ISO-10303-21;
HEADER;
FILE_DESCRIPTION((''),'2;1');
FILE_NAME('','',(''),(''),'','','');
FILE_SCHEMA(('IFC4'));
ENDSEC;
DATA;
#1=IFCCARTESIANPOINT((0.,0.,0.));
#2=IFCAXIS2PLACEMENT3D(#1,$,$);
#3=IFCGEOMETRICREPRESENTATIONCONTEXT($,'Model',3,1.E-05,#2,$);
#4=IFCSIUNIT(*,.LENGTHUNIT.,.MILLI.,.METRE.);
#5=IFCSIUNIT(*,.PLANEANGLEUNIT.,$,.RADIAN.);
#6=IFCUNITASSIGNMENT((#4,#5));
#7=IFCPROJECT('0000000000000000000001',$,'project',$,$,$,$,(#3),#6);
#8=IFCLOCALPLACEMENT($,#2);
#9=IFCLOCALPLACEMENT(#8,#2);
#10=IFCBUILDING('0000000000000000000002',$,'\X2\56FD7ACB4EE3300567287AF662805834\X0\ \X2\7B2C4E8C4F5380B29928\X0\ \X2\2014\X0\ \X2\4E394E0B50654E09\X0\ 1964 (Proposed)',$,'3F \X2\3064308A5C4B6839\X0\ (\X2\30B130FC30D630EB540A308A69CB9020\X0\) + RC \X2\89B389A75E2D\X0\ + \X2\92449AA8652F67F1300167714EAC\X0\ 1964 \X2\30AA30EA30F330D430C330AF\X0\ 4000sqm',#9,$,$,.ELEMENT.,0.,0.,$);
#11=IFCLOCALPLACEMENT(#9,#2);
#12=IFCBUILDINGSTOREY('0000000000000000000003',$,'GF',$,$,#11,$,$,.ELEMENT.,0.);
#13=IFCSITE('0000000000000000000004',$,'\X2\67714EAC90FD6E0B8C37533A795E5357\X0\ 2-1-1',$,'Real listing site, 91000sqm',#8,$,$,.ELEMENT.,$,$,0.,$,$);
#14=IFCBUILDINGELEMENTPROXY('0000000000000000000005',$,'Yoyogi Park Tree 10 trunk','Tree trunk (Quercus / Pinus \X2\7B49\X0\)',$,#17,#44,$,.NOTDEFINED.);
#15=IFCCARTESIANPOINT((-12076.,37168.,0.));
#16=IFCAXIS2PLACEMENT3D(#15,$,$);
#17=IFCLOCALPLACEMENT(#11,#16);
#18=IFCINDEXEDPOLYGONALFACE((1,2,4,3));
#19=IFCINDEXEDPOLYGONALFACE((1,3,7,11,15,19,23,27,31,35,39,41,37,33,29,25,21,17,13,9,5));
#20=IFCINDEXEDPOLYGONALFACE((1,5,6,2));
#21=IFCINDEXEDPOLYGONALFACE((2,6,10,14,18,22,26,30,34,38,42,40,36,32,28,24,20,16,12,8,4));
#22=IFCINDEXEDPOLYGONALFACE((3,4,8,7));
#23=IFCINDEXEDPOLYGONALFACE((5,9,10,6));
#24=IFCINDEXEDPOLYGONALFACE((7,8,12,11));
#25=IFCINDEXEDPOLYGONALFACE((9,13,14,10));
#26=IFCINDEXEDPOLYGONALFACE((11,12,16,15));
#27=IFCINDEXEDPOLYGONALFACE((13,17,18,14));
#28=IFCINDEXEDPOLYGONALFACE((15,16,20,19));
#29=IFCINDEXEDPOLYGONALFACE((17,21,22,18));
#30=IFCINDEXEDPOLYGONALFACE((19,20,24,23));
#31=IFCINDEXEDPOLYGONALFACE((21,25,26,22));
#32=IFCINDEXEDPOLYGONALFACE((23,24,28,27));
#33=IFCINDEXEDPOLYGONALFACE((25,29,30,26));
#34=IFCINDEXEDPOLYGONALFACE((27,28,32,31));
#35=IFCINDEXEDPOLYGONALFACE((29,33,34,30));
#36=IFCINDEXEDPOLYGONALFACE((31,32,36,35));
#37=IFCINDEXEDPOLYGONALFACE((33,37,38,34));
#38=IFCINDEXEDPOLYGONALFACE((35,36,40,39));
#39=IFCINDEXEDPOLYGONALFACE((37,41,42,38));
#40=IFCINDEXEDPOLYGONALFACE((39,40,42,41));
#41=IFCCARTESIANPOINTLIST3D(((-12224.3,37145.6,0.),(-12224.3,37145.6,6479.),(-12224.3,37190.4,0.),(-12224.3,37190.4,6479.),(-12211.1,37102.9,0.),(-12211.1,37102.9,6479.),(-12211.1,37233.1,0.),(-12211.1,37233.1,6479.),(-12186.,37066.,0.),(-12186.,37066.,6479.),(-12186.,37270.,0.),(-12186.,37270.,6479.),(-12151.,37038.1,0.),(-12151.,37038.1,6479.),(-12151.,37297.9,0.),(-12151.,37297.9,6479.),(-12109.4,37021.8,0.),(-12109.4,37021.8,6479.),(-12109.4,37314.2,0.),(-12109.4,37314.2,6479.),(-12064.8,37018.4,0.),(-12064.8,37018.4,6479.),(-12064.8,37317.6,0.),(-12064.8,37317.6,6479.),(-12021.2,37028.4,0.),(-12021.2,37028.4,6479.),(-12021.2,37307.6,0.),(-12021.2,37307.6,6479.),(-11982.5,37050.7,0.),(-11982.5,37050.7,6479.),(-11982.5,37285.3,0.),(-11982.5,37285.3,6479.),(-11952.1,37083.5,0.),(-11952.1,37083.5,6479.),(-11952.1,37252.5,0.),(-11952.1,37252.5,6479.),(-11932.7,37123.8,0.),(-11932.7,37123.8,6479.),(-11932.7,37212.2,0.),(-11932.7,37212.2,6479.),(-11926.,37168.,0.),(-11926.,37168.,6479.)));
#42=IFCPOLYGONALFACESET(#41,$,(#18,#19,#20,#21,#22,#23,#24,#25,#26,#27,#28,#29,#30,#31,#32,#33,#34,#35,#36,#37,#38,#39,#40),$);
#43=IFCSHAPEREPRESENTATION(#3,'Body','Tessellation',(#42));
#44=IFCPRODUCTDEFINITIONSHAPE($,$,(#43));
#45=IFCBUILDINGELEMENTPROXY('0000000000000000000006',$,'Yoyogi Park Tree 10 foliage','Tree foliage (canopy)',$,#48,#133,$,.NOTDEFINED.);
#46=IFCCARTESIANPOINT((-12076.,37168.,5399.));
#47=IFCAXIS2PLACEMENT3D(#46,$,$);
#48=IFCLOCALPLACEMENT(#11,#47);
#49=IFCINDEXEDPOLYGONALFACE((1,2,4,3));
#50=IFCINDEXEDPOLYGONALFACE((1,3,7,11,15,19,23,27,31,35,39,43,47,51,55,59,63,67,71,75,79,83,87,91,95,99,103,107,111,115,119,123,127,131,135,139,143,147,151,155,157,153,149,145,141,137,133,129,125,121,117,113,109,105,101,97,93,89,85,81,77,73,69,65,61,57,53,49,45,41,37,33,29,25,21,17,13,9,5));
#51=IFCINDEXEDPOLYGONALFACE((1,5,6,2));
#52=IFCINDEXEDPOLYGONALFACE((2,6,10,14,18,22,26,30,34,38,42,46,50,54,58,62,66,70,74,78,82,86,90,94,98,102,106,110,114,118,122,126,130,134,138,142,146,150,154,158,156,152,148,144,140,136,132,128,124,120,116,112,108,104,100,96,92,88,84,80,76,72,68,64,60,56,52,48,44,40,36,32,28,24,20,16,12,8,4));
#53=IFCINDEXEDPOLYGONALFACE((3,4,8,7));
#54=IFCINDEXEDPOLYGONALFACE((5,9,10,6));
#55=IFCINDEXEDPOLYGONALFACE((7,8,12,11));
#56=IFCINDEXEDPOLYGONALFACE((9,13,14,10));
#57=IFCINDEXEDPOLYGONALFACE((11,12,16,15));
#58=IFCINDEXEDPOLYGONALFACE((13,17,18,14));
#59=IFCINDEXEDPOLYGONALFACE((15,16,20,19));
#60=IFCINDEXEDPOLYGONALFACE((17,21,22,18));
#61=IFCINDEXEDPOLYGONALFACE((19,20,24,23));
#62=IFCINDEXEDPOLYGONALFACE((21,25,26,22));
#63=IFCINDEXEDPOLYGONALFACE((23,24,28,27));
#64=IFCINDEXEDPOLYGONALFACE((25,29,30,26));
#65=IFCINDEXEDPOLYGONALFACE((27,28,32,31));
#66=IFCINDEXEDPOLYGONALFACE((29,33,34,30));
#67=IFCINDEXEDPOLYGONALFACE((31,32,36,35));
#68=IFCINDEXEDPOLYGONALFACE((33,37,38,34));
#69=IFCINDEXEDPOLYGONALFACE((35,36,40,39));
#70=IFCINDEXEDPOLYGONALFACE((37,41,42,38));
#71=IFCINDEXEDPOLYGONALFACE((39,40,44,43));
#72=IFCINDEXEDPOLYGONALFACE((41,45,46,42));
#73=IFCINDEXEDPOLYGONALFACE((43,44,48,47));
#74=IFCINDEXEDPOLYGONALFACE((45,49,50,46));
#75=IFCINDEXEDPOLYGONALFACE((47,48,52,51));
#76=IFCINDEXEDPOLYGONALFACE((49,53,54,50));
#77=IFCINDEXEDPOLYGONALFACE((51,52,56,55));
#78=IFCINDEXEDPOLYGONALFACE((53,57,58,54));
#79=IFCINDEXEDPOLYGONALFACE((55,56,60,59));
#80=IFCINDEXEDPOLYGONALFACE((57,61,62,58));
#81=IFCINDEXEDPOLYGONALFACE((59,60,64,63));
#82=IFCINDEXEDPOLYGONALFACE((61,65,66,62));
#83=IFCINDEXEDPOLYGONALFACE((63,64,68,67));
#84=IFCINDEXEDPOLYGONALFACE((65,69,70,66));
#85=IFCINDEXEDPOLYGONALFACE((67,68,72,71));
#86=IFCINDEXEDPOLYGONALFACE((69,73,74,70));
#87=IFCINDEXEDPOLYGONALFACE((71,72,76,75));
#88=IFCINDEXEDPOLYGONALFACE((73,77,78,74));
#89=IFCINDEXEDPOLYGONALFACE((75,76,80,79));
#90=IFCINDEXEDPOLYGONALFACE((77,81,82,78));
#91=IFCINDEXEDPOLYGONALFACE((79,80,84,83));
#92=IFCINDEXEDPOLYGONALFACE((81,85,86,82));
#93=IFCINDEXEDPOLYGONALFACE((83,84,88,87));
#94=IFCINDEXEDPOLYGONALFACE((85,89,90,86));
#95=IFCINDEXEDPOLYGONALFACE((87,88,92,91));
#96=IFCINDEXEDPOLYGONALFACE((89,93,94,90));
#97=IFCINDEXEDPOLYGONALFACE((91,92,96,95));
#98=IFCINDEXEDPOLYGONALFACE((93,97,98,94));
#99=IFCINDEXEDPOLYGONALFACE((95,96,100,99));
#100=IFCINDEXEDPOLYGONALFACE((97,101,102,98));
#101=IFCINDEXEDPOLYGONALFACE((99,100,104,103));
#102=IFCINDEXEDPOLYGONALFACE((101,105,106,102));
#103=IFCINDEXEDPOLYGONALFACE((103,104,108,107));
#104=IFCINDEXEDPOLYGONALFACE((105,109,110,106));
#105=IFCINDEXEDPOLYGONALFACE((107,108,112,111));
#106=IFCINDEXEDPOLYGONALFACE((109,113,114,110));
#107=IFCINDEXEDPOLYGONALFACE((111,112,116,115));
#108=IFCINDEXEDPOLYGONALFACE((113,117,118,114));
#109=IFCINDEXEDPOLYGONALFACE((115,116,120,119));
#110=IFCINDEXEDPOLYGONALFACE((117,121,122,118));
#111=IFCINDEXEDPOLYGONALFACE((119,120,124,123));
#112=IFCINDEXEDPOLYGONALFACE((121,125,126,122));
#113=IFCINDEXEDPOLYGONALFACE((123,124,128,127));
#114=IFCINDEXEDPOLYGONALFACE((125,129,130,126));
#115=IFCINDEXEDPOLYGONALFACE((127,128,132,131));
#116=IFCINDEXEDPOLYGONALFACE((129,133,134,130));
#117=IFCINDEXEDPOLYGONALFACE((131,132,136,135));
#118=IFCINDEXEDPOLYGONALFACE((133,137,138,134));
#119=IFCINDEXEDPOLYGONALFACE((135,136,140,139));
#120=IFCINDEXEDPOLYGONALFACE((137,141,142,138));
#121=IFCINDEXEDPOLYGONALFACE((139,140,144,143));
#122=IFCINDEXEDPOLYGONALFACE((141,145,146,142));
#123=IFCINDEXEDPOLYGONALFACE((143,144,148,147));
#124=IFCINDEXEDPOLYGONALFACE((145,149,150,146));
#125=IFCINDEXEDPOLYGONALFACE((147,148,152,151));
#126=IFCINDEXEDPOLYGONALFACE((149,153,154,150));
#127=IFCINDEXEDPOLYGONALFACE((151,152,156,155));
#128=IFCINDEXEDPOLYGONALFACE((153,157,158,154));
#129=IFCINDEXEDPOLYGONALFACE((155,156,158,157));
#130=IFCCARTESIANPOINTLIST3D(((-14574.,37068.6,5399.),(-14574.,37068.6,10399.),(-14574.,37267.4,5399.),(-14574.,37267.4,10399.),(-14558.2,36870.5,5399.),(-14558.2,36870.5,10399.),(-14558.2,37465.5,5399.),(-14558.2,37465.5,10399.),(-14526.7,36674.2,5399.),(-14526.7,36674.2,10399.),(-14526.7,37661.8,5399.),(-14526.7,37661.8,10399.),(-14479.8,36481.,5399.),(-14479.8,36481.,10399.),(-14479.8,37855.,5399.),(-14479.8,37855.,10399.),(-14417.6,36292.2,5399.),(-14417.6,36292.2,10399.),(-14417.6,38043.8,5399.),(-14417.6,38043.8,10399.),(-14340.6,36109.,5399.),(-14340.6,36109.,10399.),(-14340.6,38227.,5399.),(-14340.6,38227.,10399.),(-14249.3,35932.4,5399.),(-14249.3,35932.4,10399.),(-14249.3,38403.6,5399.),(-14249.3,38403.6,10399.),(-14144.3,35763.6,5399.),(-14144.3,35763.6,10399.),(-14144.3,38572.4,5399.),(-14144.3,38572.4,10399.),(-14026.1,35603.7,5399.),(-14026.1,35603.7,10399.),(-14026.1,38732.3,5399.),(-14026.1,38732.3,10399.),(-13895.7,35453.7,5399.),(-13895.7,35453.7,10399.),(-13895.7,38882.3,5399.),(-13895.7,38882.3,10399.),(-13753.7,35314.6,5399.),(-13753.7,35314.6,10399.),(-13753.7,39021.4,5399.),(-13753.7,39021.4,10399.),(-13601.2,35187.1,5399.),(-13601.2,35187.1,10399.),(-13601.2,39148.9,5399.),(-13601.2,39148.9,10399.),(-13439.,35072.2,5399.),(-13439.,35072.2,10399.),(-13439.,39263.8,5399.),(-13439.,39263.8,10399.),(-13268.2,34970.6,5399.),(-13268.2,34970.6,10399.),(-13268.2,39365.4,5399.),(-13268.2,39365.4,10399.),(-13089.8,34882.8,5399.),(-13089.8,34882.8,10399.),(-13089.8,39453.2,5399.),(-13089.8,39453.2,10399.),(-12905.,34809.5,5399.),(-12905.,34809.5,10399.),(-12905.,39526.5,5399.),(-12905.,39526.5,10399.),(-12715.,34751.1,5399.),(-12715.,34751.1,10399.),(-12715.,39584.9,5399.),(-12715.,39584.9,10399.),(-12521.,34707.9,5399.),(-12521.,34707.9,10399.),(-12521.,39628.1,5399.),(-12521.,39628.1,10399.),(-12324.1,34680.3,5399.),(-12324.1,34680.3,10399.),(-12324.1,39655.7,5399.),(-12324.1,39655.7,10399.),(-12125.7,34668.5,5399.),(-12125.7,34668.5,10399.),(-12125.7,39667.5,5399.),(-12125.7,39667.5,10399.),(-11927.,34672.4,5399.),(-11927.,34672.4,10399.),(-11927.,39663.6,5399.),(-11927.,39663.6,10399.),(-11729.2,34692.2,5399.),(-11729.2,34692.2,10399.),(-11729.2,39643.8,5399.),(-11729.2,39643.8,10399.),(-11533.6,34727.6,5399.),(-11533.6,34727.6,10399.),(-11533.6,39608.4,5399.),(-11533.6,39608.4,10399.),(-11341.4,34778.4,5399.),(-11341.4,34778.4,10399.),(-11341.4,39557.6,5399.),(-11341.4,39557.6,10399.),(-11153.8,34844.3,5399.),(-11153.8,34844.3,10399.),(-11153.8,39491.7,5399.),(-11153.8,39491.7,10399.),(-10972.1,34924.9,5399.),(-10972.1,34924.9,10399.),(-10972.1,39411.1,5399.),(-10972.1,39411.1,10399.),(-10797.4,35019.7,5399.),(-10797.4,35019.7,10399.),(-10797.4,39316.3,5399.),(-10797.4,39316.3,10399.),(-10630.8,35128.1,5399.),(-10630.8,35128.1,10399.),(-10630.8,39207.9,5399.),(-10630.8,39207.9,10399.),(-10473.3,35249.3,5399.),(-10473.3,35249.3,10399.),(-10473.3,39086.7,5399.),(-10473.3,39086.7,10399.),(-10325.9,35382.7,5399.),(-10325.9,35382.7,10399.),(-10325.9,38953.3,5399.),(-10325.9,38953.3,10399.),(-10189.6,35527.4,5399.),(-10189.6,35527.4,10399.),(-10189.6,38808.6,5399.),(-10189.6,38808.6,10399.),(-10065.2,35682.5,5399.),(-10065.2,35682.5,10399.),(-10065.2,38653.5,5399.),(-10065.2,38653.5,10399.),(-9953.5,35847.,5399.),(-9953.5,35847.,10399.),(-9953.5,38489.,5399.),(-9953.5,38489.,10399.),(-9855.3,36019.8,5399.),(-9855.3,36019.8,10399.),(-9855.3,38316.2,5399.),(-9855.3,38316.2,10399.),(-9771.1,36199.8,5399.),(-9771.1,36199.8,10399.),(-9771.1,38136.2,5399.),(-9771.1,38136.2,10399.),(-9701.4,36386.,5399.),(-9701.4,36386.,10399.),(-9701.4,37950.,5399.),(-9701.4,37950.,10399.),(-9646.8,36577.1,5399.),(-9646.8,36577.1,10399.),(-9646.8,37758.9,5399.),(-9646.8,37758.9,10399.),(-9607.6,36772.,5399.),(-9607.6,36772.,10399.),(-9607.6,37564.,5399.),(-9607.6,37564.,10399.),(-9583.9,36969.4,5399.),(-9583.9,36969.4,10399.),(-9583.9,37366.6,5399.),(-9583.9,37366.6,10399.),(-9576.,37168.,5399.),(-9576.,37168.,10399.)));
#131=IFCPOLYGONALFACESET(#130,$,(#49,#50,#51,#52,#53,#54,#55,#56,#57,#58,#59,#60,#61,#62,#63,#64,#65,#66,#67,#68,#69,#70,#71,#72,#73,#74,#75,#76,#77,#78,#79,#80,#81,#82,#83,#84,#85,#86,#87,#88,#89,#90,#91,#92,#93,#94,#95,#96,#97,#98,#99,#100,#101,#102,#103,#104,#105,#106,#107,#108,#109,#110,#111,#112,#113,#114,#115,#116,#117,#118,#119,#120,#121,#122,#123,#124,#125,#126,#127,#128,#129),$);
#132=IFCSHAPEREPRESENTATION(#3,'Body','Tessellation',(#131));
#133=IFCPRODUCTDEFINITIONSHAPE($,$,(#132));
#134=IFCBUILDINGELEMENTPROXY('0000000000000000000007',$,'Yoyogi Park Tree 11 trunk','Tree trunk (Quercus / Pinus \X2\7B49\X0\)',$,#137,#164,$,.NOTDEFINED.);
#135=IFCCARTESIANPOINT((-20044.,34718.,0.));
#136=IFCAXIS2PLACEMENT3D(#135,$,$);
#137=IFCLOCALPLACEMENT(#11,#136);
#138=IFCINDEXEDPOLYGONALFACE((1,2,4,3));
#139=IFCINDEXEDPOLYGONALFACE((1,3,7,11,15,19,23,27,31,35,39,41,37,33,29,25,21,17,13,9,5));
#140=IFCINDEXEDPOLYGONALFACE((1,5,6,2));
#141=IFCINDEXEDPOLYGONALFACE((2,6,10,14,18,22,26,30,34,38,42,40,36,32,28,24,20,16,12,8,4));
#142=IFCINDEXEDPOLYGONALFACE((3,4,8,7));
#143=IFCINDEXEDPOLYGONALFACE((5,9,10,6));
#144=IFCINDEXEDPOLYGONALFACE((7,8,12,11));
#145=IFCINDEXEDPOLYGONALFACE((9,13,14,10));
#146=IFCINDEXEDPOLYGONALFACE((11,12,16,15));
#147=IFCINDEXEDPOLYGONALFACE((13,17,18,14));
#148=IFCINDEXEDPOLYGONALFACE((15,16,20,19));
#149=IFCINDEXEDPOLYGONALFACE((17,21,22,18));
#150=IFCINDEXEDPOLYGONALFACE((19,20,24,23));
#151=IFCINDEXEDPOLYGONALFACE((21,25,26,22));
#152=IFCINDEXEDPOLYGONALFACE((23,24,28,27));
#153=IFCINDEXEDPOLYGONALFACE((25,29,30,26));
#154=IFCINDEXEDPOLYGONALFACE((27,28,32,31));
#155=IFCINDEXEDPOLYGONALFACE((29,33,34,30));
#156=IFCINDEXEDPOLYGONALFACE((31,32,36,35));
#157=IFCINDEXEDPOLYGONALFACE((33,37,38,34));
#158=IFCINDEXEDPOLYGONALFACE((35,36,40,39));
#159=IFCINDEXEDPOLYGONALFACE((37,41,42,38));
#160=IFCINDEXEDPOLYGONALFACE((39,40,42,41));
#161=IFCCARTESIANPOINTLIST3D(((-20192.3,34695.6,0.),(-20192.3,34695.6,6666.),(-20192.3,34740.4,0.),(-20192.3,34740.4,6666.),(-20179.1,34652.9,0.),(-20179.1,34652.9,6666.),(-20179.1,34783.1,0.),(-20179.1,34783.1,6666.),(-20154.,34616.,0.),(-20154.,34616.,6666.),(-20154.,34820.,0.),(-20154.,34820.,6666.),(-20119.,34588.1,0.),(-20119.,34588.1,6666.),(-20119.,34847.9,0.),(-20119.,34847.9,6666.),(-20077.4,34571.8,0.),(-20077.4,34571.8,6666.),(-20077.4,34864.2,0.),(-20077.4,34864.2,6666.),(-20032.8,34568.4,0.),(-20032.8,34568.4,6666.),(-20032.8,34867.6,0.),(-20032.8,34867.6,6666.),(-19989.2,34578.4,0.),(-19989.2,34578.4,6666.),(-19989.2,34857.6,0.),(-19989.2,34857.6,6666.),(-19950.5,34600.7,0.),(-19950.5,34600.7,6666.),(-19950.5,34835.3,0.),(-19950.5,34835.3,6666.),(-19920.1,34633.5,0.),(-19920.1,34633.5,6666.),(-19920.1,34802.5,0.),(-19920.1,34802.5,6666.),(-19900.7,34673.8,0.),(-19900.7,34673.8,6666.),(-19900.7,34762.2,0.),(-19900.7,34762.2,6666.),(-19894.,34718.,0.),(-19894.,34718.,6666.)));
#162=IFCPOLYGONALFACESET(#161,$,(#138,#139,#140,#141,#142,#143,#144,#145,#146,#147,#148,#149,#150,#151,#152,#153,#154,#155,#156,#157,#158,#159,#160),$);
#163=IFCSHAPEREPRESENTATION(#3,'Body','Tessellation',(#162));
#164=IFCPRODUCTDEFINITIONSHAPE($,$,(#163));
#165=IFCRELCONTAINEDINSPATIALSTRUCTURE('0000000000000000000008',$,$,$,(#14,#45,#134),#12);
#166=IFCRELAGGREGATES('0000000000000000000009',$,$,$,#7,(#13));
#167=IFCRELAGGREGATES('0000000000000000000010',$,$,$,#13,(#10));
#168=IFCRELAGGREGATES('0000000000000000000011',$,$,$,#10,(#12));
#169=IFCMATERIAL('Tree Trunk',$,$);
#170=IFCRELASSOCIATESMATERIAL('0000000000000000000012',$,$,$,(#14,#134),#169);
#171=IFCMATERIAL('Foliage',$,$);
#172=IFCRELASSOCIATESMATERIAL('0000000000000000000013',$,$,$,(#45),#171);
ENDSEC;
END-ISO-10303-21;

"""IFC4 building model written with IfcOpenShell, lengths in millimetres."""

from ifc_helpers import new_model, si_unit, frame, origin, origin_2d, place, context, project, spatial, circle, extrude, material, element, save


model = new_model("IFC4")

# Units and contexts
model_context = context("Model", 3, precision=1e-05, world=origin())
ifc_project = project(units=[si_unit("LENGTHUNIT", "METRE", prefix="MILLI"), si_unit("PLANEANGLEUNIT", "RADIAN")], contexts=[model_context])

# Site, building, storey
site_placement = place(None, origin())
site = spatial("IfcSite", under=ifc_project, at=site_placement, Name="東京都渋谷区神南 2-1-1", ObjectType="Real listing site, 91000sqm", CompositionType="ELEMENT", RefElevation=0.0)
building_placement = place(site_placement, origin())
building = spatial("IfcBuilding", under=site, at=building_placement, Name="国立代々木競技場 第二体育館 — 丹下健三 1964 (Proposed)", ObjectType="3F つり屋根 (ケーブル吊り構造) + RC 観覧席 + 鉄骨支柱、東京 1964 オリンピック 4000sqm", CompositionType="ELEMENT", ElevationOfRefHeight=0.0, ElevationOfTerrain=0.0)
storey_placement = place(building_placement, origin())
storey = spatial("IfcBuildingStorey", under=building, at=storey_placement, Name="GF", CompositionType="ELEMENT", Elevation=0.0)

# Building element proxies
ifc_material_1 = material(Name="Tree Trunk")
proxy_1_placement = place(storey_placement, frame((-12076.0, 37168.0, 0.0)))
element("IfcBuildingElementProxy", 1, at=proxy_1_placement, inside=storey, material=ifc_material_1, Name="Yoyogi Park Tree 10 trunk", Description="Tree trunk (Quercus / Pinus 等)", PredefinedType="NOTDEFINED", context=model_context, shape_type="SweptSolid", body=[
    extrude(circle(Radius=150.0, at=origin_2d()), frame((-12076.0, 37168.0, 0.0)), (0.0, 0.0, 1.0), 6479.0),
])
ifc_material_2 = material(Name="Foliage")
proxy_2_placement = place(storey_placement, frame((-12076.0, 37168.0, 5399.0)))
element("IfcBuildingElementProxy", 2, at=proxy_2_placement, inside=storey, material=ifc_material_2, Name="Yoyogi Park Tree 10 foliage", Description="Tree foliage (canopy)", PredefinedType="NOTDEFINED", context=model_context, shape_type="SweptSolid", body=[
    extrude(circle(Radius=2500.0, at=origin_2d()), frame((-12076.0, 37168.0, 5399.0)), (0.0, 0.0, 1.0), 5000.0),
])
proxy_3_placement = place(storey_placement, frame((-20044.0, 34718.0, 0.0)))
element("IfcBuildingElementProxy", 3, at=proxy_3_placement, inside=storey, material=ifc_material_1, Name="Yoyogi Park Tree 11 trunk", Description="Tree trunk (Quercus / Pinus 等)", PredefinedType="NOTDEFINED", context=model_context, shape_type="SweptSolid", body=[
    extrude(circle(Radius=150.0, at=origin_2d()), frame((-20044.0, 34718.0, 0.0)), (0.0, 0.0, 1.0), 6666.0),
])

save(model, "model.ifc")
